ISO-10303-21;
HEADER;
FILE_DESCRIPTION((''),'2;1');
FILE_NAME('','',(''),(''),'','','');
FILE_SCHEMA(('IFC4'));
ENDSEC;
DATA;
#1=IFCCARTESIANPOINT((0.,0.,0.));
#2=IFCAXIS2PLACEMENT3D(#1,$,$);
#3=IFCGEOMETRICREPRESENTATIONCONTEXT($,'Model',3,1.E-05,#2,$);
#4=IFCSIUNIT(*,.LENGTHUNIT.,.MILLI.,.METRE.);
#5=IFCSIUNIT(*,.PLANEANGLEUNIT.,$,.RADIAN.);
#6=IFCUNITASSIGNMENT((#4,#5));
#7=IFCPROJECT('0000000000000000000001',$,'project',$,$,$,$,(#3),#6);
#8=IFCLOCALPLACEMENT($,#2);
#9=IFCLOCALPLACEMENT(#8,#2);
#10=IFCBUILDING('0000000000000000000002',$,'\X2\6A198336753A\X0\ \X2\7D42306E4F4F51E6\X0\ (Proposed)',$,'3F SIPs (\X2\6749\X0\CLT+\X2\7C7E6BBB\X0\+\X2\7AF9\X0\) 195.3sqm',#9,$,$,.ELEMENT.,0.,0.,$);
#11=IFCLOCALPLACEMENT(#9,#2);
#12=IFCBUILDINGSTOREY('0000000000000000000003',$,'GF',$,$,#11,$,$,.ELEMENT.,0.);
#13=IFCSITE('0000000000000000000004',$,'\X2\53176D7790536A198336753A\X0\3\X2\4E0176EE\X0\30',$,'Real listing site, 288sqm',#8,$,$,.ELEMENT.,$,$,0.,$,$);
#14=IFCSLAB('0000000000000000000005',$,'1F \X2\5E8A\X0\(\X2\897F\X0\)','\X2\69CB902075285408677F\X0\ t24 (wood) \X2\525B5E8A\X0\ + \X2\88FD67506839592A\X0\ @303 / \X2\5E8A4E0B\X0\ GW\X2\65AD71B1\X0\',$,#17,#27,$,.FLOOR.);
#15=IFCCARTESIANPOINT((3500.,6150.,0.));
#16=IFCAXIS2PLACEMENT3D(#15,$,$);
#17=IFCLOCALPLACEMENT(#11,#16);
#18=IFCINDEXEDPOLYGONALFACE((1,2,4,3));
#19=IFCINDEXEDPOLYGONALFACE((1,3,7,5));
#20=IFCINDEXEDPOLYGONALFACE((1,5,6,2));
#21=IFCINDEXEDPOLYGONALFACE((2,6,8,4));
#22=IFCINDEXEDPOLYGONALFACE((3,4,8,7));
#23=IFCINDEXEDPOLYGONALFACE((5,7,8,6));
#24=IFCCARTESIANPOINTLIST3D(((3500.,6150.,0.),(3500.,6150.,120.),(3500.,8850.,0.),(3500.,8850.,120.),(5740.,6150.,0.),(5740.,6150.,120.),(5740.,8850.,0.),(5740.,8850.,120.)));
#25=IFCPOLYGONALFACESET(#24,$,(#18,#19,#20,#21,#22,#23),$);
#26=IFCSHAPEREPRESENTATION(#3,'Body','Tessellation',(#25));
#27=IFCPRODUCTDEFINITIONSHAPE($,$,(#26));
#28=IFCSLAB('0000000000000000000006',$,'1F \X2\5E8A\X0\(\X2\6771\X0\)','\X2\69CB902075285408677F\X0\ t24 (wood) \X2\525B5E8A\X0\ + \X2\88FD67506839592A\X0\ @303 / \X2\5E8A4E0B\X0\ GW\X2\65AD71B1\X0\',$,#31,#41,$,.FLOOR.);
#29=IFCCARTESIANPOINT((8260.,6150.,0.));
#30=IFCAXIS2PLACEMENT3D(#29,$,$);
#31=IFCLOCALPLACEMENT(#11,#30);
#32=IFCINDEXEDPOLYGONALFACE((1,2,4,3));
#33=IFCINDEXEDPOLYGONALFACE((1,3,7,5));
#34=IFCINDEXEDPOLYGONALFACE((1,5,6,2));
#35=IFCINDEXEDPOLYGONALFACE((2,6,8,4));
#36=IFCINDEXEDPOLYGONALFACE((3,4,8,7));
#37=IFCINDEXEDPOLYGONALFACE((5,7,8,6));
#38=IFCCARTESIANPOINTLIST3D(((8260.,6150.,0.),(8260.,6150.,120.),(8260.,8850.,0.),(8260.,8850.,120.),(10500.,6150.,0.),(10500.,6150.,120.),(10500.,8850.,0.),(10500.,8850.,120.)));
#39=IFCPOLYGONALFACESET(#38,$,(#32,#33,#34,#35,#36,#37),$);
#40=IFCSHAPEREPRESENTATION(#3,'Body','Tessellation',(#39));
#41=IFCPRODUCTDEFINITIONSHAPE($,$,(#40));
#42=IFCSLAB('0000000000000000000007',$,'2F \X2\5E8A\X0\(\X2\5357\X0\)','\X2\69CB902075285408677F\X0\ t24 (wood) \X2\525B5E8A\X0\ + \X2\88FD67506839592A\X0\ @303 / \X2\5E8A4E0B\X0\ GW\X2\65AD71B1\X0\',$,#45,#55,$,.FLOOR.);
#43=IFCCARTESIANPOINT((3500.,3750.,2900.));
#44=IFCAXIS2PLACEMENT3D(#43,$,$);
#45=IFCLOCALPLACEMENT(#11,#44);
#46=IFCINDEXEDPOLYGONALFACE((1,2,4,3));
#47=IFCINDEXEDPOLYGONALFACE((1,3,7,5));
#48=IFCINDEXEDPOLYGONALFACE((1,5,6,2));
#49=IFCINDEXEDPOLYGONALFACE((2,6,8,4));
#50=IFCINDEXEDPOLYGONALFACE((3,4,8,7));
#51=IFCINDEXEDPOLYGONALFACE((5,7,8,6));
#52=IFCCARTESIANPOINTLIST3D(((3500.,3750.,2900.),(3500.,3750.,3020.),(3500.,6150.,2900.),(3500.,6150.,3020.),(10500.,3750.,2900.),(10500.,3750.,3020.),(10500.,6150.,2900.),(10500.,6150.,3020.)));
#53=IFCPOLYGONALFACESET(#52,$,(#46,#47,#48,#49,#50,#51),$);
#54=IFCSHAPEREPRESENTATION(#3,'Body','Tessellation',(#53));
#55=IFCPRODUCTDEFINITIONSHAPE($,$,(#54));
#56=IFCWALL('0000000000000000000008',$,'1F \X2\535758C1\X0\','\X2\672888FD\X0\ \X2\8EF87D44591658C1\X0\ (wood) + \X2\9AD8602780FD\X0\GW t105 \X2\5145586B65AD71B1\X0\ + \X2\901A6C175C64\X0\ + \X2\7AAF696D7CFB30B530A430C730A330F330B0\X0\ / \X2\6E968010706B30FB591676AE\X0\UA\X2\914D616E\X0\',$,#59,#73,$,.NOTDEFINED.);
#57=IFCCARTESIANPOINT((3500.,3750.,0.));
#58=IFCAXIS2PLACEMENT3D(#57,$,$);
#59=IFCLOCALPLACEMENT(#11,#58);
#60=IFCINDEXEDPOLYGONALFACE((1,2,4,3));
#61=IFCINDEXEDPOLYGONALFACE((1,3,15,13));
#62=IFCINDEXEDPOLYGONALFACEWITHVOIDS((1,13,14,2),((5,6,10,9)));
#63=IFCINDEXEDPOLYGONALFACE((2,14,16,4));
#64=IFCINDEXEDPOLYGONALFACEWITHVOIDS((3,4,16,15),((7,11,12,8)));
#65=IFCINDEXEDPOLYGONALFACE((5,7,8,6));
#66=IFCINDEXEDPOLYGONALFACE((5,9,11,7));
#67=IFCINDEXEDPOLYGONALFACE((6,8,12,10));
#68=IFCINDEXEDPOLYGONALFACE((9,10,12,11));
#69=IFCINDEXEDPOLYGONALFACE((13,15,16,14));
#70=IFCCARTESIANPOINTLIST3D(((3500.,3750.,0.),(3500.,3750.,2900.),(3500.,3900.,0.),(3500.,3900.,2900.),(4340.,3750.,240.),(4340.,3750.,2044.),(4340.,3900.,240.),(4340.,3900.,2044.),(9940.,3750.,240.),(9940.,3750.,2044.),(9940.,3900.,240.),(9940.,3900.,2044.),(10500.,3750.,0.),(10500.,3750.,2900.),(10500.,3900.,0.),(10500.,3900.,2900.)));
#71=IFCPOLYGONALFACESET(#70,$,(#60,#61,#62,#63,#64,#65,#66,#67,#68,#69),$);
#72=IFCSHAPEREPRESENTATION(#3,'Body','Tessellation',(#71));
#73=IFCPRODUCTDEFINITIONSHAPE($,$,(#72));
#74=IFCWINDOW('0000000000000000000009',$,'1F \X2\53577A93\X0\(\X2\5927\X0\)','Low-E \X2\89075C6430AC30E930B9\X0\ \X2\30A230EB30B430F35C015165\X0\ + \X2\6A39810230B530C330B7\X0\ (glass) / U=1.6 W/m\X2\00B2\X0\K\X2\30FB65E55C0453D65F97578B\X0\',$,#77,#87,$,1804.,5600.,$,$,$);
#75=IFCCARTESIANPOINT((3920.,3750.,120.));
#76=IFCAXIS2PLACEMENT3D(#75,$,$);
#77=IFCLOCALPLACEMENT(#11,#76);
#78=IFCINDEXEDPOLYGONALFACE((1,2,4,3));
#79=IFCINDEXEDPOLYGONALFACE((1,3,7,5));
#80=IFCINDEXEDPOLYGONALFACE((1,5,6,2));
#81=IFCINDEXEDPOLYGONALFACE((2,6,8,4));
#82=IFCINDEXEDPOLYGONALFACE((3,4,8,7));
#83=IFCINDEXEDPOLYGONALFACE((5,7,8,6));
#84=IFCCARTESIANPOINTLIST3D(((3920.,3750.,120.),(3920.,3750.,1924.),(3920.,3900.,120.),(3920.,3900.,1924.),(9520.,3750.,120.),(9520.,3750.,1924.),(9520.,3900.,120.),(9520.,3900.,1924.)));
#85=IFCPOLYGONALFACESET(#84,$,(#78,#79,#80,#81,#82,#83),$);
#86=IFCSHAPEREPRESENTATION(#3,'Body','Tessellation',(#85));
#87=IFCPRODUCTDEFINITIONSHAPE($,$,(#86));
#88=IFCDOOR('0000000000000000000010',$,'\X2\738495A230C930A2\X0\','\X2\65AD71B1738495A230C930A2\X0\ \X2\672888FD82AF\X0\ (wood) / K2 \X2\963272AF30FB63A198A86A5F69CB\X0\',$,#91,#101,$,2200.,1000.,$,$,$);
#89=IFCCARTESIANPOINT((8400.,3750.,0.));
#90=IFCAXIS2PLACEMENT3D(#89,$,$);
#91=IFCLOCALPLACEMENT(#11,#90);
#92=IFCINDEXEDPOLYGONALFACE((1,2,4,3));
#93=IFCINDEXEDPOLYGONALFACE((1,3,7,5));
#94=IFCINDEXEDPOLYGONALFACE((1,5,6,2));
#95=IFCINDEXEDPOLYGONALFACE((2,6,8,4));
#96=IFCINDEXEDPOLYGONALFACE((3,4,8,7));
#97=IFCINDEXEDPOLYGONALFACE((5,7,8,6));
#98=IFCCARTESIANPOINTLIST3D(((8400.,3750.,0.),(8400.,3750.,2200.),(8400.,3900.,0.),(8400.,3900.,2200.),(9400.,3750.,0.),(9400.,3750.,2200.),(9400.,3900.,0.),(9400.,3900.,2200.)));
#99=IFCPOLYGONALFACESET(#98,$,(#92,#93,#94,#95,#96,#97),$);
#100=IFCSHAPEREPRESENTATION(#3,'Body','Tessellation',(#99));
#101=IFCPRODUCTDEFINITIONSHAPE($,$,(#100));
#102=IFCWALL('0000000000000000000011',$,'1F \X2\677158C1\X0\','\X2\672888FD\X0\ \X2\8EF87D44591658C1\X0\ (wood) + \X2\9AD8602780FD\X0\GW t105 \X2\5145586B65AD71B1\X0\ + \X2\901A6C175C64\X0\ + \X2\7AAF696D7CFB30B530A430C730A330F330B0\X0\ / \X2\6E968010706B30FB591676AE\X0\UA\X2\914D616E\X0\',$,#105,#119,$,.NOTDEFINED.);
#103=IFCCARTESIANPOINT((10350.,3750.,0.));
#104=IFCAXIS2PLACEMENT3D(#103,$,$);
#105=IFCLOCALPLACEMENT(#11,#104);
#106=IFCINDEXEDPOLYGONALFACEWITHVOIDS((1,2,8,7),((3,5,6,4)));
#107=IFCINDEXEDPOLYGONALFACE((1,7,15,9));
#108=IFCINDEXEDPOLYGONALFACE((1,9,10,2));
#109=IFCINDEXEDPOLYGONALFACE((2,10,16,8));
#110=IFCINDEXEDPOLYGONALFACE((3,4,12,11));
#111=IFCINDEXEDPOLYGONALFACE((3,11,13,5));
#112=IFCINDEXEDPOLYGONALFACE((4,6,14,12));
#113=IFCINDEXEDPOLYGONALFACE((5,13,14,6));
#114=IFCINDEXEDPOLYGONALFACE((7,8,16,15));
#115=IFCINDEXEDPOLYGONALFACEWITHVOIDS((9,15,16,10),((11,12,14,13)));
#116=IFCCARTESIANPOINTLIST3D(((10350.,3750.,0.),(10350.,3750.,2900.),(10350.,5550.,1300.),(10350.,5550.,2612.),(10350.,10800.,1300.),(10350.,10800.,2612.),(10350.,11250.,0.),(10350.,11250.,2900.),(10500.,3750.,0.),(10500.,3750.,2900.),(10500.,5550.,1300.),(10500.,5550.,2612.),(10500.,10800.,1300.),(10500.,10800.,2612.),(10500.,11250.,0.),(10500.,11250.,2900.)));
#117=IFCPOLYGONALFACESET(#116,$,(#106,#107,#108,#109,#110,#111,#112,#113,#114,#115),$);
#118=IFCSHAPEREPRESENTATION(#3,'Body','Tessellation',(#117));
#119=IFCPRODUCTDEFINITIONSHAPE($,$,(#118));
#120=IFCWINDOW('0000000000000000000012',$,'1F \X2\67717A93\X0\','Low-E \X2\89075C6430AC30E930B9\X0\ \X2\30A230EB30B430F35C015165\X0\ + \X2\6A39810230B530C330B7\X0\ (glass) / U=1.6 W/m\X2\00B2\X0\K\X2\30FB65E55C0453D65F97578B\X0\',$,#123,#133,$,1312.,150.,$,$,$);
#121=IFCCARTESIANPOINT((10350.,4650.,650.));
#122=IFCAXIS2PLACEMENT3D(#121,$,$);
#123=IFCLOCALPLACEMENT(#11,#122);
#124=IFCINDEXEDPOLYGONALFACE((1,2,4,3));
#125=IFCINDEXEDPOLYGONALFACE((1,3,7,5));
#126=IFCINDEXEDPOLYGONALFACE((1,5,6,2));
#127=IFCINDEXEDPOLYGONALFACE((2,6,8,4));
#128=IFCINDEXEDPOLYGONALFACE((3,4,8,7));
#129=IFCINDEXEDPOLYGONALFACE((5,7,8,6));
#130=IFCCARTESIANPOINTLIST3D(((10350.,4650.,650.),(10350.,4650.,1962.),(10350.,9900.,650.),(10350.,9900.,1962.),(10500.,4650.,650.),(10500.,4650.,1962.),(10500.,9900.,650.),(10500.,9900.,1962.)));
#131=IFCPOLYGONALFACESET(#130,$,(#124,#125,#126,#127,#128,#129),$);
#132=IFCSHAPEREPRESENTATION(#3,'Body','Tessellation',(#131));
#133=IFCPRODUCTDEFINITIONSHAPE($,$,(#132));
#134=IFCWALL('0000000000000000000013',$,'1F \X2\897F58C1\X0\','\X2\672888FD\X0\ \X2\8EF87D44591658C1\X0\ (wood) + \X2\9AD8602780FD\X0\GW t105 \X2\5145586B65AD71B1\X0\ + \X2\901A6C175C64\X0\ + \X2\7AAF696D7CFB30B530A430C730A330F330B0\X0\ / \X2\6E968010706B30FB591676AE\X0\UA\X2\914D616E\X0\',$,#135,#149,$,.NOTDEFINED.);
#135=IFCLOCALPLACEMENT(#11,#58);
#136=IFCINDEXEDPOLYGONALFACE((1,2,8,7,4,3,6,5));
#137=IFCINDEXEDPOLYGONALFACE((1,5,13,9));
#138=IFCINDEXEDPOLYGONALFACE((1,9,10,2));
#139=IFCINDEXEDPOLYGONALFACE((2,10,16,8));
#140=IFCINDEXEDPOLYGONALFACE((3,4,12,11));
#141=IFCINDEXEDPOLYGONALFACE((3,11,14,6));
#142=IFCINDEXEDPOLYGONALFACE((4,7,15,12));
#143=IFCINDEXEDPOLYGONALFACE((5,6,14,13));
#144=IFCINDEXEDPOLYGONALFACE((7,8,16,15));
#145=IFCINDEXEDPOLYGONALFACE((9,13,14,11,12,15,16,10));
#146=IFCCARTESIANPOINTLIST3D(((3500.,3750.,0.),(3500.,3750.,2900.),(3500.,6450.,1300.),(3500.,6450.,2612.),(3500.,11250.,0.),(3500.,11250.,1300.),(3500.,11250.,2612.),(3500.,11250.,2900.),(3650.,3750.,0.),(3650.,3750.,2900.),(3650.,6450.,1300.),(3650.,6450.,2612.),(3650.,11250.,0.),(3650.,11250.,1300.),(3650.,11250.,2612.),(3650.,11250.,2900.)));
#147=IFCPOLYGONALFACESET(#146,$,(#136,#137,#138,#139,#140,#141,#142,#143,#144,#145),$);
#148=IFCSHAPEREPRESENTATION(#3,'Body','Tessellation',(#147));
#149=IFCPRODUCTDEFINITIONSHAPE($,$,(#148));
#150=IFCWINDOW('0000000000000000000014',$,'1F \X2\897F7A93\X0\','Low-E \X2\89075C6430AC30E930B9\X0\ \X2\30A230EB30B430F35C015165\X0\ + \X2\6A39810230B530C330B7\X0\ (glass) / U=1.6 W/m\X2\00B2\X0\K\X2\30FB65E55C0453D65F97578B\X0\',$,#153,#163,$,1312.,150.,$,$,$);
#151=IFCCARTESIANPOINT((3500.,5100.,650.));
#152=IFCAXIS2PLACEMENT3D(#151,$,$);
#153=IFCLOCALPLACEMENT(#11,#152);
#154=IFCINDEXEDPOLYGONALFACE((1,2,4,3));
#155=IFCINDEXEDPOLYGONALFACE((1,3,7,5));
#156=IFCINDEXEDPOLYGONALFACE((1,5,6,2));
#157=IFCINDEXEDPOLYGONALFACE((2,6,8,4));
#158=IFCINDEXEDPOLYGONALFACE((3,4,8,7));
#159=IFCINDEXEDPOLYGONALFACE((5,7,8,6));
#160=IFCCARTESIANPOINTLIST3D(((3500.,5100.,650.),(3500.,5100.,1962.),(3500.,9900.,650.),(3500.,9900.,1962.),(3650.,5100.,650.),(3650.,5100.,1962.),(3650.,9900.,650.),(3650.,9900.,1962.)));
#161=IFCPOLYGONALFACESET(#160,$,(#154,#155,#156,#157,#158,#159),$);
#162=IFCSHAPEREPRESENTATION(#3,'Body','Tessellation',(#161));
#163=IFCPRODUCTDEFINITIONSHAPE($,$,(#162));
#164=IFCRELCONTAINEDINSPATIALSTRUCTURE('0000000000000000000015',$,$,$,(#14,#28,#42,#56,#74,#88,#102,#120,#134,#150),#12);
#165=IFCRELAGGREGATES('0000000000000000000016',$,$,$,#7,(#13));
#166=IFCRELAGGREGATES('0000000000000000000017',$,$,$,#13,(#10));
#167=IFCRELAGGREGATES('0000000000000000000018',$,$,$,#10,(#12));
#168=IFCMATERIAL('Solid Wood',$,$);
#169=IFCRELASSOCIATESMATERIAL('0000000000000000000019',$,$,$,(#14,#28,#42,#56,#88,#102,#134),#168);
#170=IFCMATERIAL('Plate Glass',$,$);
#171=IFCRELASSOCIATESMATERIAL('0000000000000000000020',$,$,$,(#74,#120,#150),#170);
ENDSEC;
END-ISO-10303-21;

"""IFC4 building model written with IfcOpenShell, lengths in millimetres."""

from ifc_helpers import new_model, si_unit, frame, frame_2d, origin, place, context, project, spatial, rectangle, extrude, material, element, fill, save


model = new_model("IFC4")

# Units and contexts
model_context = context("Model", 3, precision=1e-05, world=origin())
ifc_project = project(units=[si_unit("LENGTHUNIT", "METRE", prefix="MILLI"), si_unit("PLANEANGLEUNIT", "RADIAN")], contexts=[model_context])

# Site, building, storey
site_placement = place(None, origin())
site = spatial("IfcSite", under=ifc_project, at=site_placement, Name="北海道標茶町3丁目30", ObjectType="Real listing site, 288sqm", CompositionType="ELEMENT", RefElevation=0.0)
building_placement = place(site_placement, origin())
building = spatial("IfcBuilding", under=site, at=building_placement, Name="標茶町 終の住処 (Proposed)", ObjectType="3F SIPs (杉CLT+籾殻+竹) 195.3sqm", CompositionType="ELEMENT", ElevationOfRefHeight=0.0, ElevationOfTerrain=0.0)
storey_placement = place(building_placement, origin())
storey = spatial("IfcBuildingStorey", under=building, at=storey_placement, Name="GF", CompositionType="ELEMENT", Elevation=0.0)

# Slabs
ifc_material_1 = material(Name="Solid Wood")
slab_1_placement = place(storey_placement, frame((3500.0, 6150.0, 0.0)))
element("IfcSlab", 1, at=slab_1_placement, inside=storey, material=ifc_material_1, Name="1F 床(西)", Description="構造用合板 t24 (wood) 剛床 + 製材根太 @303 / 床下 GW断熱", PredefinedType="FLOOR", context=model_context, shape_type="SweptSolid", body=[
    extrude(rectangle(XDim=2240.0, YDim=2700.0, at=frame_2d((1120.0, 1350.0))), frame((3500.0, 6150.0, 0.0)), (0.0, 0.0, 1.0), 120.0),
])
slab_2_placement = place(storey_placement, frame((8260.0, 6150.0, 0.0)))
element("IfcSlab", 2, at=slab_2_placement, inside=storey, material=ifc_material_1, Name="1F 床(東)", Description="構造用合板 t24 (wood) 剛床 + 製材根太 @303 / 床下 GW断熱", PredefinedType="FLOOR", context=model_context, shape_type="SweptSolid", body=[
    extrude(rectangle(XDim=2240.0, YDim=2700.0, at=frame_2d((1120.0, 1350.0))), frame((8260.0, 6150.0, 0.0)), (0.0, 0.0, 1.0), 120.0),
])
slab_3_placement = place(storey_placement, frame((3500.0, 3750.0, 2900.0)))
element("IfcSlab", 3, at=slab_3_placement, inside=storey, material=ifc_material_1, Name="2F 床(南)", Description="構造用合板 t24 (wood) 剛床 + 製材根太 @303 / 床下 GW断熱", PredefinedType="FLOOR", context=model_context, shape_type="SweptSolid", body=[
    extrude(rectangle(XDim=7000.0, YDim=2400.0, at=frame_2d((3500.0, 1200.0))), frame((3500.0, 3750.0, 2900.0)), (0.0, 0.0, 1.0), 120.0),
])

# Wall, openings, window, door
wall_1_placement = place(storey_placement, frame((3500.0, 3750.0, 0.0)))
wall_1 = element("IfcWall", 4, at=wall_1_placement, inside=storey, material=ifc_material_1, Name="1F 南壁", Description="木製 軸組外壁 (wood) + 高性能GW t105 充填断熱 + 通気層 + 窯業系サイディング / 準耐火・外皮UA配慮", PredefinedType="NOTDEFINED", context=model_context, shape_type="SweptSolid", body=[
    extrude(rectangle(XDim=7000.0, YDim=150.0, at=frame_2d((3500.0, 75.0))), frame((3500.0, 3750.0, 0.0)), (0.0, 0.0, 1.0), 2900.0),
])
opening_1_placement = place(storey_placement, frame((3920.0, 3750.0, 120.0)))
opening_1 = element("IfcOpeningElement", 5, at=opening_1_placement, cuts=wall_1, PredefinedType="NOTDEFINED", context=model_context, shape_type="SweptSolid", body=[
    extrude(rectangle(XDim=5600.0, YDim=150.0, at=frame_2d((2800.0, 75.0))), frame((3920.0, 3750.0, 120.0)), (0.0, 0.0, 1.0), 1804.0),
])
opening_2_placement = place(storey_placement, frame((8400.0, 3750.0, 0.0)))
opening_2 = element("IfcOpeningElement", 6, at=opening_2_placement, cuts=wall_1, PredefinedType="NOTDEFINED", context=model_context, shape_type="SweptSolid", body=[
    extrude(rectangle(XDim=1000.0, YDim=150.0, at=frame_2d((500.0, 75.0))), frame((8400.0, 3750.0, 0.0)), (0.0, 0.0, 1.0), 2200.0),
])
ifc_material_2 = material(Name="Plate Glass")
window_1_placement = place(storey_placement, frame((3920.0, 3750.0, 120.0)))
window_1 = element("IfcWindow", 7, at=window_1_placement, inside=storey, material=ifc_material_2, Name="1F 南窓(大)", Description="Low-E 複層ガラス アルゴン封入 + 樹脂サッシ (glass) / U=1.6 W/m²K・日射取得型", OverallHeight=1804.0, OverallWidth=5600.0, context=model_context, shape_type="SweptSolid", body=[
    extrude(rectangle(XDim=5600.0, YDim=150.0, at=frame_2d((2800.0, 75.0))), frame((3920.0, 3750.0, 120.0)), (0.0, 0.0, 1.0), 1804.0),
])
fill(opening_1, window_1)
door_placement = place(storey_placement, frame((8400.0, 3750.0, 0.0)))
door = element("IfcDoor", 8, at=door_placement, inside=storey, material=ifc_material_1, Name="玄関ドア", Description="断熱玄関ドア 木製芯 (wood) / K2 防犯・採風機構", OverallHeight=2200.0, OverallWidth=1000.0, context=model_context, shape_type="SweptSolid", body=[
    extrude(rectangle(XDim=1000.0, YDim=150.0, at=frame_2d((500.0, 75.0))), frame((8400.0, 3750.0, 0.0)), (0.0, 0.0, 1.0), 2200.0),
])
fill(opening_2, door)

# Walls, openings, windows
wall_2_placement = place(storey_placement, frame((10350.0, 3750.0, 0.0)))
wall_2 = element("IfcWall", 9, at=wall_2_placement, inside=storey, material=ifc_material_1, Name="1F 東壁", Description="木製 軸組外壁 (wood) + 高性能GW t105 充填断熱 + 通気層 + 窯業系サイディング / 準耐火・外皮UA配慮", PredefinedType="NOTDEFINED", context=model_context, shape_type="SweptSolid", body=[
    extrude(rectangle(XDim=150.0, YDim=7500.0, at=frame_2d((75.0, 3750.0))), frame((10350.0, 3750.0, 0.0)), (0.0, 0.0, 1.0), 2900.0),
])
opening_3_placement = place(storey_placement, frame((10350.0, 4650.0, 650.0)))
opening_3 = element("IfcOpeningElement", 10, at=opening_3_placement, cuts=wall_2, PredefinedType="NOTDEFINED", context=model_context, shape_type="SweptSolid", body=[
    extrude(rectangle(XDim=150.0, YDim=5250.0, at=frame_2d((75.0, 2625.0))), frame((10350.0, 4650.0, 650.0)), (0.0, 0.0, 1.0), 1312.0),
])
window_2_placement = place(storey_placement, frame((10350.0, 4650.0, 650.0)))
window_2 = element("IfcWindow", 11, at=window_2_placement, inside=storey, material=ifc_material_2, Name="1F 東窓", Description="Low-E 複層ガラス アルゴン封入 + 樹脂サッシ (glass) / U=1.6 W/m²K・日射取得型", OverallHeight=1312.0, OverallWidth=150.0, context=model_context, shape_type="SweptSolid", body=[
    extrude(rectangle(XDim=150.0, YDim=5250.0, at=frame_2d((75.0, 2625.0))), frame((10350.0, 4650.0, 650.0)), (0.0, 0.0, 1.0), 1312.0),
])
fill(opening_3, window_2)
wall_3_placement = place(storey_placement, frame((3500.0, 3750.0, 0.0)))
wall_3 = element("IfcWall", 12, at=wall_3_placement, inside=storey, material=ifc_material_1, Name="1F 西壁", Description="木製 軸組外壁 (wood) + 高性能GW t105 充填断熱 + 通気層 + 窯業系サイディング / 準耐火・外皮UA配慮", PredefinedType="NOTDEFINED", context=model_context, shape_type="SweptSolid", body=[
    extrude(rectangle(XDim=150.0, YDim=7500.0, at=frame_2d((75.0, 3750.0))), frame((3500.0, 3750.0, 0.0)), (0.0, 0.0, 1.0), 2900.0),
])
opening_4_placement = place(storey_placement, frame((3500.0, 5100.0, 650.0)))
opening_4 = element("IfcOpeningElement", 13, at=opening_4_placement, cuts=wall_3, PredefinedType="NOTDEFINED", context=model_context, shape_type="SweptSolid", body=[
    extrude(rectangle(XDim=150.0, YDim=4800.0, at=frame_2d((75.0, 2400.0))), frame((3500.0, 5100.0, 650.0)), (0.0, 0.0, 1.0), 1312.0),
])
window_3_placement = place(storey_placement, frame((3500.0, 5100.0, 650.0)))
window_3 = element("IfcWindow", 14, at=window_3_placement, inside=storey, material=ifc_material_2, Name="1F 西窓", Description="Low-E 複層ガラス アルゴン封入 + 樹脂サッシ (glass) / U=1.6 W/m²K・日射取得型", OverallHeight=1312.0, OverallWidth=150.0, context=model_context, shape_type="SweptSolid", body=[
    extrude(rectangle(XDim=150.0, YDim=4800.0, at=frame_2d((75.0, 2400.0))), frame((3500.0, 5100.0, 650.0)), (0.0, 0.0, 1.0), 1312.0),
])
fill(opening_4, window_3)

save(model, "model.ifc")
